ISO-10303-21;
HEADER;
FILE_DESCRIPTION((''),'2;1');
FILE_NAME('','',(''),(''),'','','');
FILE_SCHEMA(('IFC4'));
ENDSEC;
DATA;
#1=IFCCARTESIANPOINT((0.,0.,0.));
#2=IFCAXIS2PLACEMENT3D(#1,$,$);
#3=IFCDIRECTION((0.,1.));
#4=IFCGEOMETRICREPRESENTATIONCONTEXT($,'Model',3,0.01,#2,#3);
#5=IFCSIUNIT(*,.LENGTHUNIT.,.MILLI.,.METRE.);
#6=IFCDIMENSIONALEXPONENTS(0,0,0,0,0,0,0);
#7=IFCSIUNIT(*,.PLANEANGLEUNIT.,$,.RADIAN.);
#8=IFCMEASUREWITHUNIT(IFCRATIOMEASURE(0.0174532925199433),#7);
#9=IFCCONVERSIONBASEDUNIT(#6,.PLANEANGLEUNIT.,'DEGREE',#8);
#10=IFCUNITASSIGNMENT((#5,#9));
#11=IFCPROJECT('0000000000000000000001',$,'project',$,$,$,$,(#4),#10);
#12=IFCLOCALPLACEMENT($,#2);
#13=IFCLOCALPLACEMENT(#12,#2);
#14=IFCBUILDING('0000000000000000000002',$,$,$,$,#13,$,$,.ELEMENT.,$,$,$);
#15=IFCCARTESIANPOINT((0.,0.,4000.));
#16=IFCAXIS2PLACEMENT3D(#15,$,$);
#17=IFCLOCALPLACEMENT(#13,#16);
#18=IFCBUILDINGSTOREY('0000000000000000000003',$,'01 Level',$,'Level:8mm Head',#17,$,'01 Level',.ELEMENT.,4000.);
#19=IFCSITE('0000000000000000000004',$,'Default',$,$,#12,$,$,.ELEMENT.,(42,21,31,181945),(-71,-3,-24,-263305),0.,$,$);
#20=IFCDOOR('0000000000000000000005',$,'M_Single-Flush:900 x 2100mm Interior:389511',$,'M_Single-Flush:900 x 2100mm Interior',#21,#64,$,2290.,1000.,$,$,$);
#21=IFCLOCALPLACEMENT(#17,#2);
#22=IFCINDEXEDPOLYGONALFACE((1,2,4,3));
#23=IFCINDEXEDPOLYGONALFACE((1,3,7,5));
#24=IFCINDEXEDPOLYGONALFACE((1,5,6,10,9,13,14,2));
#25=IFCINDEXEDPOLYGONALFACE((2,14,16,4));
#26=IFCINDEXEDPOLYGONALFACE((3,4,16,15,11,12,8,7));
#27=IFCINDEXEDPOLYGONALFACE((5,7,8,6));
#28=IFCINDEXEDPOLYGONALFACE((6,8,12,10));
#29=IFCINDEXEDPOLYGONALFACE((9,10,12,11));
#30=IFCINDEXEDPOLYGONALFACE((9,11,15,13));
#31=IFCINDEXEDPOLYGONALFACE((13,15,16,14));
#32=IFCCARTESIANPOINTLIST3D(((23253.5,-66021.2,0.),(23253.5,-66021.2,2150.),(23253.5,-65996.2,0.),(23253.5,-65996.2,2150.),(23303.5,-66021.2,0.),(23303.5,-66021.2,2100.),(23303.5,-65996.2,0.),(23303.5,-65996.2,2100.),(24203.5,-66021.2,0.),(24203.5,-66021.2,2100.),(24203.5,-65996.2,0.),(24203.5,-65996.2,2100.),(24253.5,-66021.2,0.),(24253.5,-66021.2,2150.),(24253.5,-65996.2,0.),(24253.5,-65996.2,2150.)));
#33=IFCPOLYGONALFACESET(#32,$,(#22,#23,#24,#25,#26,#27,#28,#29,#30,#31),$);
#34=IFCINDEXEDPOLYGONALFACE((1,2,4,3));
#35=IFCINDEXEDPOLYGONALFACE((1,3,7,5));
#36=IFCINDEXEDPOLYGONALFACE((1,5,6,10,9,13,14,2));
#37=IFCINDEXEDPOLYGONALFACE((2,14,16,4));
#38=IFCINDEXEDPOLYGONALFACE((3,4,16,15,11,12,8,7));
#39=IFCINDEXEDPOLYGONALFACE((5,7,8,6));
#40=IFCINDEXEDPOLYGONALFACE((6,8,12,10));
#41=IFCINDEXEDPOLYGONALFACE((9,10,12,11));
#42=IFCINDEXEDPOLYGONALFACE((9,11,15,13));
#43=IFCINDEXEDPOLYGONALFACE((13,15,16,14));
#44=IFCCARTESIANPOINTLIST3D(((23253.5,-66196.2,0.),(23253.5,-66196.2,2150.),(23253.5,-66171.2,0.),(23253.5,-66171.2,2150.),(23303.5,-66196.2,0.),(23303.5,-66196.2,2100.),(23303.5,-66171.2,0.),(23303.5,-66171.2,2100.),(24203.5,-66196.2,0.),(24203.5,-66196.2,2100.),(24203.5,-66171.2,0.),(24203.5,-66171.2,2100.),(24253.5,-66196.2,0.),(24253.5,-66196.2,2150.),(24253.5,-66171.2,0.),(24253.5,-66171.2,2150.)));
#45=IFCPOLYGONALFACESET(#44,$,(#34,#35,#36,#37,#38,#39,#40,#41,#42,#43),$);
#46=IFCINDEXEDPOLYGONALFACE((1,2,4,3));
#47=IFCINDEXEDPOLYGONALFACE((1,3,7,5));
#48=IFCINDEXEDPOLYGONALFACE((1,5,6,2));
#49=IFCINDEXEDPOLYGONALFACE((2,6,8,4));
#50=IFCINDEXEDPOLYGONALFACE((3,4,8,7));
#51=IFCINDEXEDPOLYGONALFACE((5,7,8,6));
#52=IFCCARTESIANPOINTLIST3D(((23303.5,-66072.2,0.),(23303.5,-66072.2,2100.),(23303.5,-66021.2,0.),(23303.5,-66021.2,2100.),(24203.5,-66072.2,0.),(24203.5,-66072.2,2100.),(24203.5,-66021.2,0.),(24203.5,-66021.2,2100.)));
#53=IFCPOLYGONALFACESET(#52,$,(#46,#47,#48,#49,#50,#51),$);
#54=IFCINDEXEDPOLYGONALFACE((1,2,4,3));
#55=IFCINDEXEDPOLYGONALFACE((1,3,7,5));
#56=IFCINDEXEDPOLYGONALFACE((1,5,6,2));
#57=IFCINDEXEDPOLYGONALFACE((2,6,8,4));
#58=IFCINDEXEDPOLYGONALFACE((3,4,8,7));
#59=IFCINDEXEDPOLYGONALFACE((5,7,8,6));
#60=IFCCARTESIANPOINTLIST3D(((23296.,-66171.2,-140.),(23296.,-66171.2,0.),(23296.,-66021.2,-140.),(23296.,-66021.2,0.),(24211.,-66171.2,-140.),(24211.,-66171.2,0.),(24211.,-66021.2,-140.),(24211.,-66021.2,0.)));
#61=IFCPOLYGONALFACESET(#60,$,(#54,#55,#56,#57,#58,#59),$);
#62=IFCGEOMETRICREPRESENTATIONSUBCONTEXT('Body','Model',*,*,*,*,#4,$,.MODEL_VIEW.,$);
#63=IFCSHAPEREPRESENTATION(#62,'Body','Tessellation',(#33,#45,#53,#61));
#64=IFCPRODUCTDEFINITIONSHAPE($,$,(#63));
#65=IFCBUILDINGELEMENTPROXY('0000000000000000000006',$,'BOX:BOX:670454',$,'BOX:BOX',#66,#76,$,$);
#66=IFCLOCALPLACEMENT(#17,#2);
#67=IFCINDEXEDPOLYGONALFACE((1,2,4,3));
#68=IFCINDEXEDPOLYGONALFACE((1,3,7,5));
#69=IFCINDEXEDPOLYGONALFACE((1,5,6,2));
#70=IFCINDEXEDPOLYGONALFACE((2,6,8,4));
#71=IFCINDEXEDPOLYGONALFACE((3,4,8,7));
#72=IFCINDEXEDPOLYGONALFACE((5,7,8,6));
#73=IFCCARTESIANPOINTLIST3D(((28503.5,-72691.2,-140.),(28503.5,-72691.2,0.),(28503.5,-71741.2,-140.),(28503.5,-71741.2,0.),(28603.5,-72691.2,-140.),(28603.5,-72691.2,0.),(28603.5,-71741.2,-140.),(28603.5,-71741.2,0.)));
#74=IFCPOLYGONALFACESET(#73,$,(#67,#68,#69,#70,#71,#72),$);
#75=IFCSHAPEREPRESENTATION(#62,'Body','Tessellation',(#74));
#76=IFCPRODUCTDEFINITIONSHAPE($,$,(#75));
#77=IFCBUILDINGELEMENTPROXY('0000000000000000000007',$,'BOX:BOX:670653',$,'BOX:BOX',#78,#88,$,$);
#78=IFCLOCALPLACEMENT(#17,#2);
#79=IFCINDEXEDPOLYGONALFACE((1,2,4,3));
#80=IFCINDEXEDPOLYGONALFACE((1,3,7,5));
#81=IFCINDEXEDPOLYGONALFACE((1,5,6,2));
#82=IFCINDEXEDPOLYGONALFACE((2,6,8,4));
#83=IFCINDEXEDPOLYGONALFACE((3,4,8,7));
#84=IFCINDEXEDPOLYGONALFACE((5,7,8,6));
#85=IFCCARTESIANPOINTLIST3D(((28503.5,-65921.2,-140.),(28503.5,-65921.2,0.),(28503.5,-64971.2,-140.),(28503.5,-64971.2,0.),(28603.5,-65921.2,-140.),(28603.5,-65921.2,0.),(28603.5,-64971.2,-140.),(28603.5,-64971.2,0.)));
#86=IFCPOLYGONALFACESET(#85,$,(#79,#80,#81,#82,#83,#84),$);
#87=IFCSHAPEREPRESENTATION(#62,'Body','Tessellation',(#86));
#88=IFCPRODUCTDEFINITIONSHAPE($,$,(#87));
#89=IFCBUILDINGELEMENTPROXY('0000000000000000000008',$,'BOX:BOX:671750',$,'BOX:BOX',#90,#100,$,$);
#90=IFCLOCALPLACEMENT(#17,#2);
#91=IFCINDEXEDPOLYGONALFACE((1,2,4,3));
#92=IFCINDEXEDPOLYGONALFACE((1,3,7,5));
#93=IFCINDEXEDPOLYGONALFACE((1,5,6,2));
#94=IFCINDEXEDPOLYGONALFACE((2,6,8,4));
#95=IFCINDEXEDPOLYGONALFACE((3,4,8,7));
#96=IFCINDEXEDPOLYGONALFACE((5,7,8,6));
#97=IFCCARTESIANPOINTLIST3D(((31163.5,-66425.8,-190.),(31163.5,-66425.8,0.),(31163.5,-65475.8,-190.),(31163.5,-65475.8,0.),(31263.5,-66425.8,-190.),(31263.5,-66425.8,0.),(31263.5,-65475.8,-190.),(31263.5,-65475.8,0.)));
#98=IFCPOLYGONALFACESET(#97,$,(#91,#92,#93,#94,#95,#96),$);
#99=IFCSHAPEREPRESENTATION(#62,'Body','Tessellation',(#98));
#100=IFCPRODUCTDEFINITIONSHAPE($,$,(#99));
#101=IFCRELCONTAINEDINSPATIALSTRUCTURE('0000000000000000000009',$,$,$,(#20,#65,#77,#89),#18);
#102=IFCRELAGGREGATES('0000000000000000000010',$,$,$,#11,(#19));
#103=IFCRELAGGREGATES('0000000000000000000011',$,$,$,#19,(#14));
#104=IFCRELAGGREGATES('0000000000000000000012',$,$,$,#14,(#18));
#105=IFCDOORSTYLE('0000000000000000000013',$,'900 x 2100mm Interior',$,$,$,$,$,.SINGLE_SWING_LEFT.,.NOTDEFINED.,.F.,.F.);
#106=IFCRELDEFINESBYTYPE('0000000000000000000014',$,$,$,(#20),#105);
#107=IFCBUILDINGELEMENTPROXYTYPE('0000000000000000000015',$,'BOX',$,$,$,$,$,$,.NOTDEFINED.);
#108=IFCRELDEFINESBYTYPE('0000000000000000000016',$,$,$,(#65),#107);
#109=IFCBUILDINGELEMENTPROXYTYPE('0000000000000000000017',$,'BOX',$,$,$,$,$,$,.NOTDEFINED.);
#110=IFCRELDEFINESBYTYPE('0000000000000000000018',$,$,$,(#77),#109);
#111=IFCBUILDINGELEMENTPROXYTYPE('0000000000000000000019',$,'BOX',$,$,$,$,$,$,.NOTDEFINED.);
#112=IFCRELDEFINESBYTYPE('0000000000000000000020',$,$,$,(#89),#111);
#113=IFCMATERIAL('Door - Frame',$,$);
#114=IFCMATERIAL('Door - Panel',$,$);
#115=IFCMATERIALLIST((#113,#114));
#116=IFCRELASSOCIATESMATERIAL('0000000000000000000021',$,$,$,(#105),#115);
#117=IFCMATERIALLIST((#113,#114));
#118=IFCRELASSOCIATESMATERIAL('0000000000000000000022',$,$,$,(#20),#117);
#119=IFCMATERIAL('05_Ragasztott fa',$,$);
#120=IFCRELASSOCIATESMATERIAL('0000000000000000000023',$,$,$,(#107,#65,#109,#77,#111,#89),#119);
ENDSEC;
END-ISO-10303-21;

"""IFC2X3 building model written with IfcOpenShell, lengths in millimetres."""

from ifc_helpers import new_model, entity, si_unit, converted_unit, direction, frame, frame_2d, origin, origin_2d_with_axis, place, context, subcontext, project, spatial, polyline, rectangle, outline, extrude, source, transform, mapped, material, material_list, type_object, type_shapes, element, save


model = new_model("IFC2X3")

# Units and contexts
model_context = context("Model", 3, precision=0.01, world=origin(), true_north=direction((0.0, 1.0)))
body_context = subcontext(model_context, "Body", "Model", "MODEL_VIEW")
ifc_project = project(units=[si_unit("LENGTHUNIT", "METRE", prefix="MILLI"), converted_unit("PLANEANGLEUNIT", "DEGREE", entity("IfcRatioMeasure", 0.0174532925199433), si_unit("PLANEANGLEUNIT", "RADIAN"), dimensions=[0, 0, 0, 0, 0, 0, 0])], contexts=[model_context])

# Site, building, storey
site_placement = place(None, origin())
site = spatial("IfcSite", under=ifc_project, at=site_placement, Name="Default", CompositionType="ELEMENT", RefLatitude=(42, 21, 31, 181945), RefLongitude=(-71, -3, -24, -263305), RefElevation=0.0)
building_placement = place(site_placement, origin())
building = spatial("IfcBuilding", under=site, at=building_placement, CompositionType="ELEMENT")
storey_placement = place(building_placement, frame((0.0, 0.0, 4000.0)))
storey = spatial("IfcBuildingStorey", under=building, at=storey_placement, Name="01 Level", ObjectType="Level:8mm Head", LongName="01 Level", CompositionType="ELEMENT", Elevation=4000.0)

# Shared definitions
ifc_material_1 = material(Name="Door - Frame")
ifc_material_2 = material(Name="Door - Panel")

# Door
ifc_material_list_1 = material_list([ifc_material_1, ifc_material_2])
ifc_material_list_2 = material_list([ifc_material_1, ifc_material_2])
door_style_1 = type_object("IfcDoorStyle", Name="900 x 2100mm Interior", ConstructionType="NOTDEFINED", OperationType="SINGLE_SWING_LEFT", ParameterTakesPrecedence=False, Sizeable=False, material=ifc_material_list_2)
shared_shape_1 = source(origin(), body_context, "Body", "SweptSolid", [
    extrude(outline(polyline([(-500.0, -1087.5), (500.0, -1087.5), (500.0, 1062.5), (450.0, 1062.5), (450.0, -1037.5), (-450.0, -1037.5), (-450.0, 1062.5), (-500.0, 1062.5), (-500.0, -1087.5)])), frame((450.0, 175.0, 1202.5), z_axis=(0.0, -1.0, 0.0), x_axis=(-1.0, 0.0, 0.0)), (0.0, 0.0, 1.0), 25.0),
    extrude(outline(polyline([(-1087.5, -500.0), (1062.5, -500.0), (1062.5, -450.0), (-1037.5, -450.0), (-1037.5, 450.0), (1062.5, 450.0), (1062.5, 500.0), (-1087.5, 500.0), (-1087.5, -500.0)])), frame((450.0, 0.0, 1202.5), z_axis=(0.0, -1.0, 0.0), x_axis=(0.0, 0.0, -1.0)), (0.0, 0.0, 1.0), 25.0),
    extrude(rectangle(XDim=900.0, YDim=51.0, at=frame_2d((0.0, 0.0), x_axis=(1.0, 0.0))), frame((450.0, 124.5, 140.0)), (0.0, 0.0, 1.0), 2100.0),
    extrude(rectangle(XDim=150.0, YDim=915.0, at=origin_2d_with_axis()), frame((450.0, 75.0, 0.0), z_axis=(0.0, 0.0, 1.0), x_axis=(0.0, -1.0, 0.0)), (0.0, 0.0, 1.0), 140.0),
])
type_shapes(door_style_1, [shared_shape_1])
door_1_placement = place(storey_placement, frame((23303.5, -66171.2, -140.0)))
element("IfcDoor", 1, at=door_1_placement, inside=storey, type_object=door_style_1, material=ifc_material_list_1, Name="M_Single-Flush:900 x 2100mm Interior:389511", ObjectType="M_Single-Flush:900 x 2100mm Interior", OverallHeight=2290.0, OverallWidth=1000.0, context=body_context, shape_type="MappedRepresentation", body=[
    mapped(shared_shape_1, transform((0.0, 0.0, 0.0), scale=1.0)),
])

# Building element proxies
ifc_material_3 = material(Name="05_Ragasztott fa")
building_element_proxy_type_1 = type_object("IfcBuildingElementProxyType", Name="BOX", PredefinedType="NOTDEFINED", material=ifc_material_3)
shared_shape_2 = source(origin(), body_context, "Body", "SweptSolid", [
    extrude(rectangle(XDim=100.0, YDim=950.0, at=frame_2d((0.0, 0.0), x_axis=(1.0, 0.0))), frame((50.0, 475.0, 0.0), z_axis=(0.0, 0.0, 1.0), x_axis=(-1.0, 0.0, 0.0)), (0.0, 0.0, 1.0), 140.0),
])
type_shapes(building_element_proxy_type_1, [shared_shape_2])
proxy_1_placement = place(storey_placement, frame((28503.5, -72691.2, -140.0)))
element("IfcBuildingElementProxy", 2, at=proxy_1_placement, inside=storey, type_object=building_element_proxy_type_1, material=ifc_material_3, Name="BOX:BOX:670454", ObjectType="BOX:BOX", context=body_context, shape_type="MappedRepresentation", body=[
    mapped(shared_shape_2, transform((0.0, 0.0, 0.0), scale=1.0)),
])
building_element_proxy_type_2 = type_object("IfcBuildingElementProxyType", Name="BOX", PredefinedType="NOTDEFINED", material=ifc_material_3)
shared_shape_3 = source(origin(), body_context, "Body", "SweptSolid", [
    extrude(rectangle(XDim=100.0, YDim=950.0, at=frame_2d((0.0, 0.0), x_axis=(1.0, 0.0))), frame((50.0, 475.0, 0.0), z_axis=(0.0, 0.0, 1.0), x_axis=(-1.0, 0.0, 0.0)), (0.0, 0.0, 1.0), 140.0),
])
type_shapes(building_element_proxy_type_2, [shared_shape_3])
proxy_2_placement = place(storey_placement, frame((28503.5, -65921.2, -140.0)))
element("IfcBuildingElementProxy", 3, at=proxy_2_placement, inside=storey, type_object=building_element_proxy_type_2, material=ifc_material_3, Name="BOX:BOX:670653", ObjectType="BOX:BOX", context=body_context, shape_type="MappedRepresentation", body=[
    mapped(shared_shape_3, transform((0.0, 0.0, 0.0), scale=1.0)),
])
building_element_proxy_type_3 = type_object("IfcBuildingElementProxyType", Name="BOX", PredefinedType="NOTDEFINED", material=ifc_material_3)
shared_shape_4 = source(origin(), body_context, "Body", "SweptSolid", [
    extrude(rectangle(XDim=100.0, YDim=950.0, at=frame_2d((0.0, 0.0), x_axis=(1.0, 0.0))), frame((50.0, 475.0, 0.0), z_axis=(0.0, 0.0, 1.0), x_axis=(-1.0, 0.0, 0.0)), (0.0, 0.0, 1.0), 190.0),
])
type_shapes(building_element_proxy_type_3, [shared_shape_4])
proxy_3_placement = place(storey_placement, frame((31163.5, -66425.8, -190.0)))
element("IfcBuildingElementProxy", 4, at=proxy_3_placement, inside=storey, type_object=building_element_proxy_type_3, material=ifc_material_3, Name="BOX:BOX:671750", ObjectType="BOX:BOX", context=body_context, shape_type="MappedRepresentation", body=[
    mapped(shared_shape_4, transform((0.0, 0.0, 0.0), scale=1.0)),
])

save(model, "model.ifc")
